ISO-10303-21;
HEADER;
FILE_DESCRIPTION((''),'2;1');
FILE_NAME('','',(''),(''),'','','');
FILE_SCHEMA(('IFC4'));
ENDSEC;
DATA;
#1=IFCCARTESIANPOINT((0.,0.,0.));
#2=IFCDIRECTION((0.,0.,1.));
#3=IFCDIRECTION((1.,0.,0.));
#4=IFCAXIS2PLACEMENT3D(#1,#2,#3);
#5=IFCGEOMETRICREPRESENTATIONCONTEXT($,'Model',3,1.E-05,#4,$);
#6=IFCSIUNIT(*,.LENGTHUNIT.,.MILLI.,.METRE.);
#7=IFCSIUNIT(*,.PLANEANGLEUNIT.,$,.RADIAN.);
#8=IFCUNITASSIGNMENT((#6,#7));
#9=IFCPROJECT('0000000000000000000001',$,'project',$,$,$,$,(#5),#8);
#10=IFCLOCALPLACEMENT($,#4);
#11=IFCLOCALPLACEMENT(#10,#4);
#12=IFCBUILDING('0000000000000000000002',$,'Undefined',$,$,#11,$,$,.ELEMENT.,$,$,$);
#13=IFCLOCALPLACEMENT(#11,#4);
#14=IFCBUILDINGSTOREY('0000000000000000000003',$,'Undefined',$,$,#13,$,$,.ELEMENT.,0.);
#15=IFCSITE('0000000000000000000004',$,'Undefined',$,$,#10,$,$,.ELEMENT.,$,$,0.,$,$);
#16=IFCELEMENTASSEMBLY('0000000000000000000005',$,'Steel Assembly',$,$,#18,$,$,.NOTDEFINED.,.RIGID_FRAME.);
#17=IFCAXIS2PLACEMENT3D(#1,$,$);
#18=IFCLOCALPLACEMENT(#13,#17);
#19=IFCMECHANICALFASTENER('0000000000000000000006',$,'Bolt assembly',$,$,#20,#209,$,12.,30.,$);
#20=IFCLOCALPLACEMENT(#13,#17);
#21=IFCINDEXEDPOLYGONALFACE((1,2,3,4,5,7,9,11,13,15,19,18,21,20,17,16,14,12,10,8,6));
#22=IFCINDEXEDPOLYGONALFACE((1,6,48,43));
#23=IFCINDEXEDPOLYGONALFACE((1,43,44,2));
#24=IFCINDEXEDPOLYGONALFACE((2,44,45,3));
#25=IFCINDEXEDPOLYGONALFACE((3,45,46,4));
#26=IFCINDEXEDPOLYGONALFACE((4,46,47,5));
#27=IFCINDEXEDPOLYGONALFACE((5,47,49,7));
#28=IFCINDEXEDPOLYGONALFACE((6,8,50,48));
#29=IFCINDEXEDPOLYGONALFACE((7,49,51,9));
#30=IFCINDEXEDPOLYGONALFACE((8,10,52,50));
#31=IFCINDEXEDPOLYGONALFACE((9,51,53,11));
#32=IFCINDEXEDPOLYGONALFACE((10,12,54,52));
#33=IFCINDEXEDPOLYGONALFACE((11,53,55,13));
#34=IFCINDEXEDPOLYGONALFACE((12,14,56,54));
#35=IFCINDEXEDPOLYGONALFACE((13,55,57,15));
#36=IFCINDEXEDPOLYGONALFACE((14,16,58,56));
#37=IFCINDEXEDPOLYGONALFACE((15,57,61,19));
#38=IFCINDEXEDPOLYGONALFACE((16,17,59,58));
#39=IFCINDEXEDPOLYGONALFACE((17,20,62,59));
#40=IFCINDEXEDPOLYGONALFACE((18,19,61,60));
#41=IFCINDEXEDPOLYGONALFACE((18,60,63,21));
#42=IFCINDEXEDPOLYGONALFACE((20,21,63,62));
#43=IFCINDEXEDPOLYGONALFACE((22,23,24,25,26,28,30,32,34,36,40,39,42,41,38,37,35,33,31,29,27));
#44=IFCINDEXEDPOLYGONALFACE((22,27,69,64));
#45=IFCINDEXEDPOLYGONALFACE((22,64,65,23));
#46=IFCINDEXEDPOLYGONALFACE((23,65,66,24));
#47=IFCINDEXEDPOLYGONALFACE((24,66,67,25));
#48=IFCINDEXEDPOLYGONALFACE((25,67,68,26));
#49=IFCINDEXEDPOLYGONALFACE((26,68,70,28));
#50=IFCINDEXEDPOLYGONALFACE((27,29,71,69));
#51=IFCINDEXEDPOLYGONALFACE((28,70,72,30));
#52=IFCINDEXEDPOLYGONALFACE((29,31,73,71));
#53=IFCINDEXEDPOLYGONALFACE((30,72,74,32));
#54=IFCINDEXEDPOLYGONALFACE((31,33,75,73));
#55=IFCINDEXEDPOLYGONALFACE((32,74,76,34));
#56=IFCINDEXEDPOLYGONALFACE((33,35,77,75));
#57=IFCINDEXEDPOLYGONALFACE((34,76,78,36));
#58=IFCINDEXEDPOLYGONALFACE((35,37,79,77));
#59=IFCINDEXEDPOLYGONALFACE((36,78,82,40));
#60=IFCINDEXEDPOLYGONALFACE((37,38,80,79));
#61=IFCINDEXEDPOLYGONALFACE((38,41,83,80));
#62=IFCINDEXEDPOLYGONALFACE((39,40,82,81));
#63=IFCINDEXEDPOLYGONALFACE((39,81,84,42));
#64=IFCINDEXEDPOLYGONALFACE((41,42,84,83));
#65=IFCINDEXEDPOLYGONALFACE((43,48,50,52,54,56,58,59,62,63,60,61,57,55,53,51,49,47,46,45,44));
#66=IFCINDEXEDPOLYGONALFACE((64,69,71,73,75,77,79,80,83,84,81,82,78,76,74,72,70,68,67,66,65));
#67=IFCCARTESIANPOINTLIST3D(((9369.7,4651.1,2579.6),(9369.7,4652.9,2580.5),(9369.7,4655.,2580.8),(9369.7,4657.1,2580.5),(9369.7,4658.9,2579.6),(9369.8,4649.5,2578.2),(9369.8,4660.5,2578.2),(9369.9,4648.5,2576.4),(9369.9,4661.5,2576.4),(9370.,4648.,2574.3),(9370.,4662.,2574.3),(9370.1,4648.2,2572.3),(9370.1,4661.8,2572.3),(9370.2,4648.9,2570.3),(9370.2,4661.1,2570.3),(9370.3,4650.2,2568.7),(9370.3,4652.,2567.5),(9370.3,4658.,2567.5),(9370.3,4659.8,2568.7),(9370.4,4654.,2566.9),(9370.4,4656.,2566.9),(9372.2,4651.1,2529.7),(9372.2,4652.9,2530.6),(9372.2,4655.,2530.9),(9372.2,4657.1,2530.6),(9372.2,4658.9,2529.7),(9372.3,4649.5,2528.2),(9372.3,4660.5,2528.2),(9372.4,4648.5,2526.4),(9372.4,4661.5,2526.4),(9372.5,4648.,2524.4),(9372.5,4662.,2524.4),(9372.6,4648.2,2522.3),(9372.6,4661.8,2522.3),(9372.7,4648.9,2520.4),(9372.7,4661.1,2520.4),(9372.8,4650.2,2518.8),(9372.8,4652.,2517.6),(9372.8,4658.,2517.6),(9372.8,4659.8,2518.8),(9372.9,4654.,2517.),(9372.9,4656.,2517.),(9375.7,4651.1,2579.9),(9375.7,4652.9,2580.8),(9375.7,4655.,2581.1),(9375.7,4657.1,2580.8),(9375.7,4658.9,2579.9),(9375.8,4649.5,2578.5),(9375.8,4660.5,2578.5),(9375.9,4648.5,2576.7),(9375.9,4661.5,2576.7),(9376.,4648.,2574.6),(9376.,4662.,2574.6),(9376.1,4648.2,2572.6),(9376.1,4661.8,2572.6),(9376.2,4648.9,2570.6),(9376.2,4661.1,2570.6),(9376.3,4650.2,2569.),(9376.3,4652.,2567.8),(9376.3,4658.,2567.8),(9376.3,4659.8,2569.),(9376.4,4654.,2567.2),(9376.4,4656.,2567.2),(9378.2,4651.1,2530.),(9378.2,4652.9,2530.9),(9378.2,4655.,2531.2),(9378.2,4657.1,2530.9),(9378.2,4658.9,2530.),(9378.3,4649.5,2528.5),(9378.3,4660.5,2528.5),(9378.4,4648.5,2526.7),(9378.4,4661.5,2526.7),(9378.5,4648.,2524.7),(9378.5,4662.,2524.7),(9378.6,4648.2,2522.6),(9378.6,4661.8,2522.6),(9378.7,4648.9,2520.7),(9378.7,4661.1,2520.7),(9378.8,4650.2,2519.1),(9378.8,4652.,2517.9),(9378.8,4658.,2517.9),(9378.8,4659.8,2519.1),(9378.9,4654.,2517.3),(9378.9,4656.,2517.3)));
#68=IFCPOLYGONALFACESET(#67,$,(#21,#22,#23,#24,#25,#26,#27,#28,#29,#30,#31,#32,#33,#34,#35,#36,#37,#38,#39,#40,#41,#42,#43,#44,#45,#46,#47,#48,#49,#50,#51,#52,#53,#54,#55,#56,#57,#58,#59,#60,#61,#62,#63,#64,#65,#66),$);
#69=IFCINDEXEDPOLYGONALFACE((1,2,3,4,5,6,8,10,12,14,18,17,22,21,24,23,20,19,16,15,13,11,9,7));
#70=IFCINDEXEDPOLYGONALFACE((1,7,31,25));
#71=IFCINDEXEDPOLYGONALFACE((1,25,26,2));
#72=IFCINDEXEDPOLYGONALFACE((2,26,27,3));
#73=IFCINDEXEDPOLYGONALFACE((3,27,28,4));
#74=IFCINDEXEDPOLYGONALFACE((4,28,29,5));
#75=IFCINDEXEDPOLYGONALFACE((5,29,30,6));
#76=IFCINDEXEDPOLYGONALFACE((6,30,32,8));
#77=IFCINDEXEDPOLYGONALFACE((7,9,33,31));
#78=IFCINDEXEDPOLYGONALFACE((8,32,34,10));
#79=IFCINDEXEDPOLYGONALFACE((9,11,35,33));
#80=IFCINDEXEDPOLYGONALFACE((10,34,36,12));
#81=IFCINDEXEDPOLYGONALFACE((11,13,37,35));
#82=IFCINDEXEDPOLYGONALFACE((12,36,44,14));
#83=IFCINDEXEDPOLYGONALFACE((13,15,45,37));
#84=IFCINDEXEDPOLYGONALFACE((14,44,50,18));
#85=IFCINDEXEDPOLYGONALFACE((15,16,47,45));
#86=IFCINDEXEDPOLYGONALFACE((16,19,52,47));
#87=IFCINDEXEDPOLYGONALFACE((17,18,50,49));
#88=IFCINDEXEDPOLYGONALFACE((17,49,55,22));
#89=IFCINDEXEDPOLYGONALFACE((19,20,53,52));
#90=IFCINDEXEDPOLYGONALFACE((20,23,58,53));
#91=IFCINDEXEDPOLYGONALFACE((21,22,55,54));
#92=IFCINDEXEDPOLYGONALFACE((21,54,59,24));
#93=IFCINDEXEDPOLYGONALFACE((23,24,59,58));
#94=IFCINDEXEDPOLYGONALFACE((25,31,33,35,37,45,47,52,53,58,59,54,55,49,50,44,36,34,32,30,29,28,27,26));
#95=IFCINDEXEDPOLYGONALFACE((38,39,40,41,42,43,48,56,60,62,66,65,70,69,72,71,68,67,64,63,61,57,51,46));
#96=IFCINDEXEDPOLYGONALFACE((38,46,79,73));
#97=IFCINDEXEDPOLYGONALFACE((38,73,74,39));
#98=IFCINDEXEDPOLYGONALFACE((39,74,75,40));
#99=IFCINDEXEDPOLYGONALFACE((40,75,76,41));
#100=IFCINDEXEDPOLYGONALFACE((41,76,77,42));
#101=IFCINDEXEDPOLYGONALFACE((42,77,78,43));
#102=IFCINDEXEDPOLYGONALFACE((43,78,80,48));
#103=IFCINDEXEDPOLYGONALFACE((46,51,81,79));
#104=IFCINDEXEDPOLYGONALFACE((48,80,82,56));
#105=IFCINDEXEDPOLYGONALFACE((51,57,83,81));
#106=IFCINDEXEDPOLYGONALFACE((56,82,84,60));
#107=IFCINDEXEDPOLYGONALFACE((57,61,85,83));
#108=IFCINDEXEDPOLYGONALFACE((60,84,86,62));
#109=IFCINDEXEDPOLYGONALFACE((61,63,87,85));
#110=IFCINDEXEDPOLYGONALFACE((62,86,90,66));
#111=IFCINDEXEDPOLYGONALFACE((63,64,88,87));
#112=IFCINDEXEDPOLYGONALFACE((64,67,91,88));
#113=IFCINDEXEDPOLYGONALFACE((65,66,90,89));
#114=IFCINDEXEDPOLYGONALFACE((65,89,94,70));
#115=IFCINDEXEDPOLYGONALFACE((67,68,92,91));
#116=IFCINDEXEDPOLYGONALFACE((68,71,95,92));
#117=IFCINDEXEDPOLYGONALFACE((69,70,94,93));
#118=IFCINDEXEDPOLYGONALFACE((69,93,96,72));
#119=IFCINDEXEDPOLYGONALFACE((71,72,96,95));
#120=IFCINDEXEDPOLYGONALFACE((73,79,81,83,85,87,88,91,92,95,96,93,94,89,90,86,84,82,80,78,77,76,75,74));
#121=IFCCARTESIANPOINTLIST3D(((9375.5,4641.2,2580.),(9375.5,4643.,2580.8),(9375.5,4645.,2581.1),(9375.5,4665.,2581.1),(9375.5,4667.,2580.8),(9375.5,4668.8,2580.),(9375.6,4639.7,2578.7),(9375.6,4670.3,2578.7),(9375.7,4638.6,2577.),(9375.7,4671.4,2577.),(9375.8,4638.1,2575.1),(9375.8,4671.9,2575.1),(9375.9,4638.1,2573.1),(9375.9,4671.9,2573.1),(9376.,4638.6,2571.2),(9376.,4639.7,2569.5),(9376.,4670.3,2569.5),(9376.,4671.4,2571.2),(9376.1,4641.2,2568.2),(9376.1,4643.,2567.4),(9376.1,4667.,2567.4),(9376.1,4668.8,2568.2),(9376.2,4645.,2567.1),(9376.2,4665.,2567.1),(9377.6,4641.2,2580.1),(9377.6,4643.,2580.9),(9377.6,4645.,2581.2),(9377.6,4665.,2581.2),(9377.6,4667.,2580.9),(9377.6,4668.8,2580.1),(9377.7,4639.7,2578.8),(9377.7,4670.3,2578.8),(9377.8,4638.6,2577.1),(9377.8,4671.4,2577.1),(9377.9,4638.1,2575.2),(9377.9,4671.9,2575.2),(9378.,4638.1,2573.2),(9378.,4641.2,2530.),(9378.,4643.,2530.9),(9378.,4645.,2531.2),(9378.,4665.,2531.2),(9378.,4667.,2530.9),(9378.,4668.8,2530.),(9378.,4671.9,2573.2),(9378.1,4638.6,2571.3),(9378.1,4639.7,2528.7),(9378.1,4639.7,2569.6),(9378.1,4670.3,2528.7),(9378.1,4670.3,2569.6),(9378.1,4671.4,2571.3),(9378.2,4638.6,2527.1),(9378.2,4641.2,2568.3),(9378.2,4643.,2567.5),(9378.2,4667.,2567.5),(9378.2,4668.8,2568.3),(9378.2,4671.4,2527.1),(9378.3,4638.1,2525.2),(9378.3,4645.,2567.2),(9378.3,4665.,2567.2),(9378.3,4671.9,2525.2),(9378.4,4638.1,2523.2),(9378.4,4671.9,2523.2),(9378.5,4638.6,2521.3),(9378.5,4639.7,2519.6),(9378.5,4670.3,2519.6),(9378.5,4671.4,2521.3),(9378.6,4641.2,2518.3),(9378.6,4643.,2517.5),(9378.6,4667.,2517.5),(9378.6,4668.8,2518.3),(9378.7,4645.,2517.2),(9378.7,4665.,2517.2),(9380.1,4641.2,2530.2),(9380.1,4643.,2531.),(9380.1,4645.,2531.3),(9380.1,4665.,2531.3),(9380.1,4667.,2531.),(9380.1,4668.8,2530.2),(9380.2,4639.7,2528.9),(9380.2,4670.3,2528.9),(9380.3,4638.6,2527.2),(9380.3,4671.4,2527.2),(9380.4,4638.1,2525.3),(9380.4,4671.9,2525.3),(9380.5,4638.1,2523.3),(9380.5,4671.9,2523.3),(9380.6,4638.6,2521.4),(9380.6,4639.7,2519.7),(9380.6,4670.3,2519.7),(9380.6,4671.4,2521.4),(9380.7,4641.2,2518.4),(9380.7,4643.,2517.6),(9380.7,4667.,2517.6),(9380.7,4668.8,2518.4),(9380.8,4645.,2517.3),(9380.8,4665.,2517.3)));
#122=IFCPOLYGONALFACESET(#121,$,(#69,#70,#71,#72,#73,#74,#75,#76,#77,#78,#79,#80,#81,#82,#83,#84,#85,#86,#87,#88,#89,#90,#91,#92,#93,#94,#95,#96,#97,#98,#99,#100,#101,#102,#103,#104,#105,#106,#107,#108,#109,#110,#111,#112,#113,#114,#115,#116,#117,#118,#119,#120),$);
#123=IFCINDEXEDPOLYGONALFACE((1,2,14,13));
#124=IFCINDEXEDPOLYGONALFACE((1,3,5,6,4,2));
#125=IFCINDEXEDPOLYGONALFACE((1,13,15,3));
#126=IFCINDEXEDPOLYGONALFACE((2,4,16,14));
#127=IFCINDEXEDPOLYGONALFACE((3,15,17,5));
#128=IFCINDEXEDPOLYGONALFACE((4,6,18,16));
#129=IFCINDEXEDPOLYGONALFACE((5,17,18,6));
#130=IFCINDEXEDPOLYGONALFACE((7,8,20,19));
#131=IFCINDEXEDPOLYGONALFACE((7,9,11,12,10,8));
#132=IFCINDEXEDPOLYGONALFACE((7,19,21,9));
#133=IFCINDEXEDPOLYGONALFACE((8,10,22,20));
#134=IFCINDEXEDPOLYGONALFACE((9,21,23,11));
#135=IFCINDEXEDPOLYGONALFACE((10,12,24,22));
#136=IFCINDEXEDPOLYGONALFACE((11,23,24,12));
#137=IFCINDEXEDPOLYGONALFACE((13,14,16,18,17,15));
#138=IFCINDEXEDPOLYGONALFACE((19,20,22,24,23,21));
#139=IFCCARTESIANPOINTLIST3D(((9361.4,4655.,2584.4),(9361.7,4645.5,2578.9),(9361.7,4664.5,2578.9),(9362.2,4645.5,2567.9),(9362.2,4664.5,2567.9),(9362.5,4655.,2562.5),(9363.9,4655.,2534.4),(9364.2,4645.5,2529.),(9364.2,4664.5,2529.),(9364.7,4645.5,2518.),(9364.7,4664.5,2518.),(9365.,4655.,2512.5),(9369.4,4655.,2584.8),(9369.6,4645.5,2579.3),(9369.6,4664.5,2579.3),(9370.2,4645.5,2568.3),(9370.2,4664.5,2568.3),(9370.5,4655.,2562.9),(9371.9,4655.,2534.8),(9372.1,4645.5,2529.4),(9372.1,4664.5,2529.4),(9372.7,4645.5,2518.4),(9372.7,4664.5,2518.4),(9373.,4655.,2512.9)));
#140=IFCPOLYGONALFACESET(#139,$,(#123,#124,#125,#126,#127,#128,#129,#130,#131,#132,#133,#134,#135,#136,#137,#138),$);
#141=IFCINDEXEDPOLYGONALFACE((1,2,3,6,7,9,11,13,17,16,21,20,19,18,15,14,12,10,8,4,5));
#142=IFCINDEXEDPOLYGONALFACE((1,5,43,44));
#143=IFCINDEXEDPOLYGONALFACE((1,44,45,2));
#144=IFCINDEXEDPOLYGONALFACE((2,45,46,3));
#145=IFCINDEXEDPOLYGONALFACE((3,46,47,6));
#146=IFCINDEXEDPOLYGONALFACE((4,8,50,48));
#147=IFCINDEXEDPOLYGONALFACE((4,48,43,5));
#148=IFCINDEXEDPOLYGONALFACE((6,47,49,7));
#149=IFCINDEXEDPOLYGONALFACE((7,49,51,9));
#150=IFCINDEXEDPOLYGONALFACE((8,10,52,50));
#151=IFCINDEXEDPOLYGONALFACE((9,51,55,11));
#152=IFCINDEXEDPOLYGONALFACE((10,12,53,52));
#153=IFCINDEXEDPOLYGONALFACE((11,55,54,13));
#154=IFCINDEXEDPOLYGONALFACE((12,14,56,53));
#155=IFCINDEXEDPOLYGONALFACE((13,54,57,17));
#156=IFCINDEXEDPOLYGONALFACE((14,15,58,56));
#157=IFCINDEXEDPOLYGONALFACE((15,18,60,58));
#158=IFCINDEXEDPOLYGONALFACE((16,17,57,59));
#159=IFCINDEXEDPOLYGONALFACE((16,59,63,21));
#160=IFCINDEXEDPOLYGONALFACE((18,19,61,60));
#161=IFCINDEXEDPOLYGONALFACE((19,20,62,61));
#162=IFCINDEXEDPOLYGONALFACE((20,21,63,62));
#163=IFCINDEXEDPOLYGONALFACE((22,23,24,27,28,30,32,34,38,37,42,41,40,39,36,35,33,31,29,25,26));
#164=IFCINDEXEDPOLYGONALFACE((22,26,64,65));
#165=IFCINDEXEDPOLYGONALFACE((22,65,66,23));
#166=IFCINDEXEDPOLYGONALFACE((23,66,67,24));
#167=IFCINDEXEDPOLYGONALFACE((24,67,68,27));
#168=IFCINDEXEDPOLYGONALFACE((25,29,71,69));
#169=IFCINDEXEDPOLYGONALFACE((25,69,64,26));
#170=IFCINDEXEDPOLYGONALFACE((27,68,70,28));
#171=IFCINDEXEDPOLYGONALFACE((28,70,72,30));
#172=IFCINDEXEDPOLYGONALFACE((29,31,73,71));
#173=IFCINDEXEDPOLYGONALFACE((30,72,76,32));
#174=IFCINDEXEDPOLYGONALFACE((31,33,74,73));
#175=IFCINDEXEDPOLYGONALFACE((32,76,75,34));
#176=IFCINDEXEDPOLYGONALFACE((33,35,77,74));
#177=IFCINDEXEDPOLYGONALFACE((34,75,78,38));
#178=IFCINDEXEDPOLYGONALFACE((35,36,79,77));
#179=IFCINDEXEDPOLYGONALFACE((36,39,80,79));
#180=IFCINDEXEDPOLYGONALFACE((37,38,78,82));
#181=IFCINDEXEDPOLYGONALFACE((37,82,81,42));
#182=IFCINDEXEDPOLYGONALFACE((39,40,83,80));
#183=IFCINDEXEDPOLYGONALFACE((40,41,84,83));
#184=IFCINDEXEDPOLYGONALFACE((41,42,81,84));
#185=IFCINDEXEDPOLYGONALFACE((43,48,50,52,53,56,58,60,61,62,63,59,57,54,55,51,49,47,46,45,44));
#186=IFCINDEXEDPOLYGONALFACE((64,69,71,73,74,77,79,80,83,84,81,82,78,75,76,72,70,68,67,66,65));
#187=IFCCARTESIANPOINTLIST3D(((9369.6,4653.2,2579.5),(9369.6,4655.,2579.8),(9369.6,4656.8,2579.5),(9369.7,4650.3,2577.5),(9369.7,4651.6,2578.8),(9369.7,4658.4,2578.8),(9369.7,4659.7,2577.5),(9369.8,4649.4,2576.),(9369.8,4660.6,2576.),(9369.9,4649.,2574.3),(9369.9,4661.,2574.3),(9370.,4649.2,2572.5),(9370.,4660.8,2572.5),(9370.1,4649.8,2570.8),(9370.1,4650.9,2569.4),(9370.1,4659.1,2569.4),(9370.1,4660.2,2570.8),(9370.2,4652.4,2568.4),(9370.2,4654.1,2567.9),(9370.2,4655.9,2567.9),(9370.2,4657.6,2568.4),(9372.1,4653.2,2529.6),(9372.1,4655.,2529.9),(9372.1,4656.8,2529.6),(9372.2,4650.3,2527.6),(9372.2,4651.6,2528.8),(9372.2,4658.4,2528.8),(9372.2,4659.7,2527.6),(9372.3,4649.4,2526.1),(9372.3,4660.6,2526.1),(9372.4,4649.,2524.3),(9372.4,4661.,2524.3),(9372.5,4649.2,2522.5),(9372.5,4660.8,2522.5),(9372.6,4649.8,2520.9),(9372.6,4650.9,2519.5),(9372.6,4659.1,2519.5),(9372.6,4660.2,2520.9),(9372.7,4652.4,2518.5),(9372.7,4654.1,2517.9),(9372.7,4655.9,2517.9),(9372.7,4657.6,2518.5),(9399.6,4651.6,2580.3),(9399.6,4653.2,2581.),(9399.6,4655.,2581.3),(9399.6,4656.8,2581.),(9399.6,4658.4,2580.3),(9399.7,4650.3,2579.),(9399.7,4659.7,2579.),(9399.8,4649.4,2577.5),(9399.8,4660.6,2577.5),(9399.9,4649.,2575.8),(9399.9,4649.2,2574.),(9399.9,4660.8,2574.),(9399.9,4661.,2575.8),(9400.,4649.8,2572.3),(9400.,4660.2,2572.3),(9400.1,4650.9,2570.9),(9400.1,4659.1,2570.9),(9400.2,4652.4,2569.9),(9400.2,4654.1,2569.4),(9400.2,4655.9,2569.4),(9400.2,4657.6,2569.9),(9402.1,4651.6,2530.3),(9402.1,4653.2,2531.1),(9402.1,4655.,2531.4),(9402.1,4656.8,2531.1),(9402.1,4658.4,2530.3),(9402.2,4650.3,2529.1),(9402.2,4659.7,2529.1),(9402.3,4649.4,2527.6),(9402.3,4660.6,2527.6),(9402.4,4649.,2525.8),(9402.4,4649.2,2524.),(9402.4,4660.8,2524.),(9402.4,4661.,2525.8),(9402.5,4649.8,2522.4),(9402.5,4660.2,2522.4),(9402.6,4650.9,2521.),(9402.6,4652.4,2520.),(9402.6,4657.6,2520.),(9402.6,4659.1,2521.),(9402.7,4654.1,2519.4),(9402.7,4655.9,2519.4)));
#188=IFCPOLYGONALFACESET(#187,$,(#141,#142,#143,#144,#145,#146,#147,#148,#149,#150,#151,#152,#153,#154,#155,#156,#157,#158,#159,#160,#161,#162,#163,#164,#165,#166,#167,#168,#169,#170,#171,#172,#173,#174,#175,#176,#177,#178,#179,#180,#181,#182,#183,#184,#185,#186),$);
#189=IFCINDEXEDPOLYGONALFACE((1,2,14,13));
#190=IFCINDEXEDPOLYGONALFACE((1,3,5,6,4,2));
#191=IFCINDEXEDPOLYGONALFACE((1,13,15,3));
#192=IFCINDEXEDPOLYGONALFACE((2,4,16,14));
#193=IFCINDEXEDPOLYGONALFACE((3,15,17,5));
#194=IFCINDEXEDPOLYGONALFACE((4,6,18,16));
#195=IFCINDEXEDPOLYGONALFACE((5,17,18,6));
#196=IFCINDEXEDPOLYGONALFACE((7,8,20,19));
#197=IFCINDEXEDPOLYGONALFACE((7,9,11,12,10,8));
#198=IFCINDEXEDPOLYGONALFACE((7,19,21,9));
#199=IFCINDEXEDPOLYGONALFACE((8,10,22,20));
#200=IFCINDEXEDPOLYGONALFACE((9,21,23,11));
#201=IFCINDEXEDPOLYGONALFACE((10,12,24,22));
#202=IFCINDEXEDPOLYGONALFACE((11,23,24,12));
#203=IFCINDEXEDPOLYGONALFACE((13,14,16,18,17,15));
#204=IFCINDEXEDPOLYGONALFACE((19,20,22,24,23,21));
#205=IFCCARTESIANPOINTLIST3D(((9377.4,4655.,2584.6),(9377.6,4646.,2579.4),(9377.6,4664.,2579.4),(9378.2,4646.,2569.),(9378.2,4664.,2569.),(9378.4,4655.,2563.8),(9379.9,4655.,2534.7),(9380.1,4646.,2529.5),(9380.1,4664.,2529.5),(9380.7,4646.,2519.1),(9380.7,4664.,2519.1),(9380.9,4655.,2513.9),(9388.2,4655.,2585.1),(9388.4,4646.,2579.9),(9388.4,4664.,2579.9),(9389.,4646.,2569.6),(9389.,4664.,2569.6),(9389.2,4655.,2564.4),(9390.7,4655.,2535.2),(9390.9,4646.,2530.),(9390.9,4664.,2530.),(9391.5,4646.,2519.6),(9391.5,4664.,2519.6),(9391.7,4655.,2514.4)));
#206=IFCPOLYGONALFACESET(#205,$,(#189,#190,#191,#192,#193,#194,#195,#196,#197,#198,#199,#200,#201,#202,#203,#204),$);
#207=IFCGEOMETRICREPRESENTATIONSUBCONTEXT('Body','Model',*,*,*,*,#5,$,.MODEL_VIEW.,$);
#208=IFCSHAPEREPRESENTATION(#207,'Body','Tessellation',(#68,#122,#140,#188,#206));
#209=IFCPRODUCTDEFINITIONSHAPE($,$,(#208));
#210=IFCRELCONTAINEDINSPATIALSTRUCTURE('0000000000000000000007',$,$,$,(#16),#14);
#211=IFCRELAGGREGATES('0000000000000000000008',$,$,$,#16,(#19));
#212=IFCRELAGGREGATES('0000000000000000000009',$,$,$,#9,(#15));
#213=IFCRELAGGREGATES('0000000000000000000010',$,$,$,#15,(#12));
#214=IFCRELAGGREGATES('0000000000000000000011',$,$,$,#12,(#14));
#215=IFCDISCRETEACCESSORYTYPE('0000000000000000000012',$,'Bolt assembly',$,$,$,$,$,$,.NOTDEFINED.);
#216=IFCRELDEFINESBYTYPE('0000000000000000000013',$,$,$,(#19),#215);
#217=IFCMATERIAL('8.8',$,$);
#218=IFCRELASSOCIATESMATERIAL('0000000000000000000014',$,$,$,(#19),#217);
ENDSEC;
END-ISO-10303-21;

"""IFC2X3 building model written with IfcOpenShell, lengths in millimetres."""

from ifc_helpers import new_model, si_unit, frame, frame_2d, origin_with_axes, origin_2d_with_axis, place, context, subcontext, project, spatial, polyline, circle_curve, parameter, trimmed, segment, composite_curve, circle, outline, extrude, source, transform, mapped, material, type_object, element, aggregate, save


model = new_model("IFC2X3")

# Units and contexts
model_context = context("Model", 3, precision=1e-05, world=origin_with_axes())
body_context = subcontext(model_context, "Body", "Model", "MODEL_VIEW")
ifc_project = project(units=[si_unit("LENGTHUNIT", "METRE", prefix="MILLI"), si_unit("PLANEANGLEUNIT", "RADIAN")], contexts=[model_context])

# Site, building, storey
site_placement = place(None, origin_with_axes())
site = spatial("IfcSite", under=ifc_project, at=site_placement, Name="Undefined", CompositionType="ELEMENT", RefElevation=0.0)
building_placement = place(site_placement, origin_with_axes())
building = spatial("IfcBuilding", under=site, at=building_placement, Name="Undefined", CompositionType="ELEMENT")
storey_placement = place(building_placement, origin_with_axes())
storey = spatial("IfcBuildingStorey", under=building, at=storey_placement, Name="Undefined", CompositionType="ELEMENT", Elevation=0.0)

# Element assembly
assembly_1_placement = place(storey_placement, origin_with_axes())
assembly_1 = element("IfcElementAssembly", 1, at=assembly_1_placement, inside=storey, Name="Steel Assembly", AssemblyPlace="NOTDEFINED", PredefinedType="RIGID_FRAME")

# Mechanical fastener
discrete_accessory_type_1 = type_object("IfcDiscreteAccessoryType", Name="Bolt assembly")
ifc_material_1 = material(Name="8.8")
shared_shape_1 = source(origin_with_axes(), body_context, "Body", "SweptSolid", [
    extrude(circle(Radius=7.0, at=origin_2d_with_axis()), frame((0.0, -2.9, 0.0), z_axis=(0.0, 1.0, 0.0), x_axis=(1.0, 0.0, 0.0)), (0.0, 0.0, 1.0), 6.0),
    extrude(outline(composite_curve([segment(polyline([(7.0, 10.0), (7.0, -10.0)]), True, "CONTINUOUS"), segment(trimmed(circle_curve(frame_2d((0.0, -10.0), x_axis=(1.0, 0.0)), 7.0), [parameter(0.0)], [parameter(3.1416)], False, "PARAMETER"), True, "CONTINUOUS"), segment(polyline([(-7.0, -10.0), (-7.0, 10.0)]), True, "CONTINUOUS"), segment(trimmed(circle_curve(frame_2d((0.0, 10.0), x_axis=(-1.0, 0.0)), 7.0), [parameter(0.0)], [parameter(3.1416)], False, "PARAMETER"), True, "DISCONTINUOUS")], self_intersect=False)), frame((0.0, 2.9, 0.0), z_axis=(0.0, 1.0, 0.0), x_axis=(1.0, 0.0, 0.0)), (0.0, 0.0, 1.0), 2.1),
    extrude(outline(polyline([(11.0, 0.0), (5.5, 9.5), (-5.5, 9.5), (-11.0, 0.0), (-5.5, -9.5), (5.5, -9.5), (11.0, 0.0)])), frame((0.0, -11.0, 0.0), z_axis=(0.0, 1.0, 0.0), x_axis=(1.0, 0.0, 0.0)), (0.0, 0.0, 1.0), 8.0),
    extrude(circle(Radius=6.0, at=origin_2d_with_axis()), frame((0.0, -3.0, 0.0), z_axis=(0.0, 1.0, 0.0), x_axis=(1.0, 0.0, 0.0)), (0.0, 0.0, 1.0), 30.0),
    extrude(outline(polyline([(10.4, 0.0), (5.2, 9.0), (-5.2, 9.0), (-10.4, 0.0), (-5.2, -9.0), (5.2, -9.0), (10.4, 0.0)])), frame((0.0, 5.0, 0.0), z_axis=(0.0, 1.0, 0.0), x_axis=(1.0, 0.0, 0.0)), (0.0, 0.0, 1.0), 10.8),
])
mechanical_fastener_1_placement = place(assembly_1_placement, frame((9376.7, 4610.0, 2499.1), z_axis=(0.0, 1.0, 0.0), x_axis=(-0.049938, 0.0, 0.998752)))
mechanical_fastener_1 = element("IfcMechanicalFastener", 2, at=mechanical_fastener_1_placement, type_object=discrete_accessory_type_1, material=ifc_material_1, Name="Bolt assembly", NominalDiameter=12.0, NominalLength=30.0, context=body_context, shape_type="MappedRepresentation", body=[
    mapped(shared_shape_1, transform((25.0, 0.0, 45.0))),
    mapped(shared_shape_1, transform((75.0, 0.0, 45.0))),
])
aggregate(assembly_1, [mechanical_fastener_1])

save(model, "model.ifc")
